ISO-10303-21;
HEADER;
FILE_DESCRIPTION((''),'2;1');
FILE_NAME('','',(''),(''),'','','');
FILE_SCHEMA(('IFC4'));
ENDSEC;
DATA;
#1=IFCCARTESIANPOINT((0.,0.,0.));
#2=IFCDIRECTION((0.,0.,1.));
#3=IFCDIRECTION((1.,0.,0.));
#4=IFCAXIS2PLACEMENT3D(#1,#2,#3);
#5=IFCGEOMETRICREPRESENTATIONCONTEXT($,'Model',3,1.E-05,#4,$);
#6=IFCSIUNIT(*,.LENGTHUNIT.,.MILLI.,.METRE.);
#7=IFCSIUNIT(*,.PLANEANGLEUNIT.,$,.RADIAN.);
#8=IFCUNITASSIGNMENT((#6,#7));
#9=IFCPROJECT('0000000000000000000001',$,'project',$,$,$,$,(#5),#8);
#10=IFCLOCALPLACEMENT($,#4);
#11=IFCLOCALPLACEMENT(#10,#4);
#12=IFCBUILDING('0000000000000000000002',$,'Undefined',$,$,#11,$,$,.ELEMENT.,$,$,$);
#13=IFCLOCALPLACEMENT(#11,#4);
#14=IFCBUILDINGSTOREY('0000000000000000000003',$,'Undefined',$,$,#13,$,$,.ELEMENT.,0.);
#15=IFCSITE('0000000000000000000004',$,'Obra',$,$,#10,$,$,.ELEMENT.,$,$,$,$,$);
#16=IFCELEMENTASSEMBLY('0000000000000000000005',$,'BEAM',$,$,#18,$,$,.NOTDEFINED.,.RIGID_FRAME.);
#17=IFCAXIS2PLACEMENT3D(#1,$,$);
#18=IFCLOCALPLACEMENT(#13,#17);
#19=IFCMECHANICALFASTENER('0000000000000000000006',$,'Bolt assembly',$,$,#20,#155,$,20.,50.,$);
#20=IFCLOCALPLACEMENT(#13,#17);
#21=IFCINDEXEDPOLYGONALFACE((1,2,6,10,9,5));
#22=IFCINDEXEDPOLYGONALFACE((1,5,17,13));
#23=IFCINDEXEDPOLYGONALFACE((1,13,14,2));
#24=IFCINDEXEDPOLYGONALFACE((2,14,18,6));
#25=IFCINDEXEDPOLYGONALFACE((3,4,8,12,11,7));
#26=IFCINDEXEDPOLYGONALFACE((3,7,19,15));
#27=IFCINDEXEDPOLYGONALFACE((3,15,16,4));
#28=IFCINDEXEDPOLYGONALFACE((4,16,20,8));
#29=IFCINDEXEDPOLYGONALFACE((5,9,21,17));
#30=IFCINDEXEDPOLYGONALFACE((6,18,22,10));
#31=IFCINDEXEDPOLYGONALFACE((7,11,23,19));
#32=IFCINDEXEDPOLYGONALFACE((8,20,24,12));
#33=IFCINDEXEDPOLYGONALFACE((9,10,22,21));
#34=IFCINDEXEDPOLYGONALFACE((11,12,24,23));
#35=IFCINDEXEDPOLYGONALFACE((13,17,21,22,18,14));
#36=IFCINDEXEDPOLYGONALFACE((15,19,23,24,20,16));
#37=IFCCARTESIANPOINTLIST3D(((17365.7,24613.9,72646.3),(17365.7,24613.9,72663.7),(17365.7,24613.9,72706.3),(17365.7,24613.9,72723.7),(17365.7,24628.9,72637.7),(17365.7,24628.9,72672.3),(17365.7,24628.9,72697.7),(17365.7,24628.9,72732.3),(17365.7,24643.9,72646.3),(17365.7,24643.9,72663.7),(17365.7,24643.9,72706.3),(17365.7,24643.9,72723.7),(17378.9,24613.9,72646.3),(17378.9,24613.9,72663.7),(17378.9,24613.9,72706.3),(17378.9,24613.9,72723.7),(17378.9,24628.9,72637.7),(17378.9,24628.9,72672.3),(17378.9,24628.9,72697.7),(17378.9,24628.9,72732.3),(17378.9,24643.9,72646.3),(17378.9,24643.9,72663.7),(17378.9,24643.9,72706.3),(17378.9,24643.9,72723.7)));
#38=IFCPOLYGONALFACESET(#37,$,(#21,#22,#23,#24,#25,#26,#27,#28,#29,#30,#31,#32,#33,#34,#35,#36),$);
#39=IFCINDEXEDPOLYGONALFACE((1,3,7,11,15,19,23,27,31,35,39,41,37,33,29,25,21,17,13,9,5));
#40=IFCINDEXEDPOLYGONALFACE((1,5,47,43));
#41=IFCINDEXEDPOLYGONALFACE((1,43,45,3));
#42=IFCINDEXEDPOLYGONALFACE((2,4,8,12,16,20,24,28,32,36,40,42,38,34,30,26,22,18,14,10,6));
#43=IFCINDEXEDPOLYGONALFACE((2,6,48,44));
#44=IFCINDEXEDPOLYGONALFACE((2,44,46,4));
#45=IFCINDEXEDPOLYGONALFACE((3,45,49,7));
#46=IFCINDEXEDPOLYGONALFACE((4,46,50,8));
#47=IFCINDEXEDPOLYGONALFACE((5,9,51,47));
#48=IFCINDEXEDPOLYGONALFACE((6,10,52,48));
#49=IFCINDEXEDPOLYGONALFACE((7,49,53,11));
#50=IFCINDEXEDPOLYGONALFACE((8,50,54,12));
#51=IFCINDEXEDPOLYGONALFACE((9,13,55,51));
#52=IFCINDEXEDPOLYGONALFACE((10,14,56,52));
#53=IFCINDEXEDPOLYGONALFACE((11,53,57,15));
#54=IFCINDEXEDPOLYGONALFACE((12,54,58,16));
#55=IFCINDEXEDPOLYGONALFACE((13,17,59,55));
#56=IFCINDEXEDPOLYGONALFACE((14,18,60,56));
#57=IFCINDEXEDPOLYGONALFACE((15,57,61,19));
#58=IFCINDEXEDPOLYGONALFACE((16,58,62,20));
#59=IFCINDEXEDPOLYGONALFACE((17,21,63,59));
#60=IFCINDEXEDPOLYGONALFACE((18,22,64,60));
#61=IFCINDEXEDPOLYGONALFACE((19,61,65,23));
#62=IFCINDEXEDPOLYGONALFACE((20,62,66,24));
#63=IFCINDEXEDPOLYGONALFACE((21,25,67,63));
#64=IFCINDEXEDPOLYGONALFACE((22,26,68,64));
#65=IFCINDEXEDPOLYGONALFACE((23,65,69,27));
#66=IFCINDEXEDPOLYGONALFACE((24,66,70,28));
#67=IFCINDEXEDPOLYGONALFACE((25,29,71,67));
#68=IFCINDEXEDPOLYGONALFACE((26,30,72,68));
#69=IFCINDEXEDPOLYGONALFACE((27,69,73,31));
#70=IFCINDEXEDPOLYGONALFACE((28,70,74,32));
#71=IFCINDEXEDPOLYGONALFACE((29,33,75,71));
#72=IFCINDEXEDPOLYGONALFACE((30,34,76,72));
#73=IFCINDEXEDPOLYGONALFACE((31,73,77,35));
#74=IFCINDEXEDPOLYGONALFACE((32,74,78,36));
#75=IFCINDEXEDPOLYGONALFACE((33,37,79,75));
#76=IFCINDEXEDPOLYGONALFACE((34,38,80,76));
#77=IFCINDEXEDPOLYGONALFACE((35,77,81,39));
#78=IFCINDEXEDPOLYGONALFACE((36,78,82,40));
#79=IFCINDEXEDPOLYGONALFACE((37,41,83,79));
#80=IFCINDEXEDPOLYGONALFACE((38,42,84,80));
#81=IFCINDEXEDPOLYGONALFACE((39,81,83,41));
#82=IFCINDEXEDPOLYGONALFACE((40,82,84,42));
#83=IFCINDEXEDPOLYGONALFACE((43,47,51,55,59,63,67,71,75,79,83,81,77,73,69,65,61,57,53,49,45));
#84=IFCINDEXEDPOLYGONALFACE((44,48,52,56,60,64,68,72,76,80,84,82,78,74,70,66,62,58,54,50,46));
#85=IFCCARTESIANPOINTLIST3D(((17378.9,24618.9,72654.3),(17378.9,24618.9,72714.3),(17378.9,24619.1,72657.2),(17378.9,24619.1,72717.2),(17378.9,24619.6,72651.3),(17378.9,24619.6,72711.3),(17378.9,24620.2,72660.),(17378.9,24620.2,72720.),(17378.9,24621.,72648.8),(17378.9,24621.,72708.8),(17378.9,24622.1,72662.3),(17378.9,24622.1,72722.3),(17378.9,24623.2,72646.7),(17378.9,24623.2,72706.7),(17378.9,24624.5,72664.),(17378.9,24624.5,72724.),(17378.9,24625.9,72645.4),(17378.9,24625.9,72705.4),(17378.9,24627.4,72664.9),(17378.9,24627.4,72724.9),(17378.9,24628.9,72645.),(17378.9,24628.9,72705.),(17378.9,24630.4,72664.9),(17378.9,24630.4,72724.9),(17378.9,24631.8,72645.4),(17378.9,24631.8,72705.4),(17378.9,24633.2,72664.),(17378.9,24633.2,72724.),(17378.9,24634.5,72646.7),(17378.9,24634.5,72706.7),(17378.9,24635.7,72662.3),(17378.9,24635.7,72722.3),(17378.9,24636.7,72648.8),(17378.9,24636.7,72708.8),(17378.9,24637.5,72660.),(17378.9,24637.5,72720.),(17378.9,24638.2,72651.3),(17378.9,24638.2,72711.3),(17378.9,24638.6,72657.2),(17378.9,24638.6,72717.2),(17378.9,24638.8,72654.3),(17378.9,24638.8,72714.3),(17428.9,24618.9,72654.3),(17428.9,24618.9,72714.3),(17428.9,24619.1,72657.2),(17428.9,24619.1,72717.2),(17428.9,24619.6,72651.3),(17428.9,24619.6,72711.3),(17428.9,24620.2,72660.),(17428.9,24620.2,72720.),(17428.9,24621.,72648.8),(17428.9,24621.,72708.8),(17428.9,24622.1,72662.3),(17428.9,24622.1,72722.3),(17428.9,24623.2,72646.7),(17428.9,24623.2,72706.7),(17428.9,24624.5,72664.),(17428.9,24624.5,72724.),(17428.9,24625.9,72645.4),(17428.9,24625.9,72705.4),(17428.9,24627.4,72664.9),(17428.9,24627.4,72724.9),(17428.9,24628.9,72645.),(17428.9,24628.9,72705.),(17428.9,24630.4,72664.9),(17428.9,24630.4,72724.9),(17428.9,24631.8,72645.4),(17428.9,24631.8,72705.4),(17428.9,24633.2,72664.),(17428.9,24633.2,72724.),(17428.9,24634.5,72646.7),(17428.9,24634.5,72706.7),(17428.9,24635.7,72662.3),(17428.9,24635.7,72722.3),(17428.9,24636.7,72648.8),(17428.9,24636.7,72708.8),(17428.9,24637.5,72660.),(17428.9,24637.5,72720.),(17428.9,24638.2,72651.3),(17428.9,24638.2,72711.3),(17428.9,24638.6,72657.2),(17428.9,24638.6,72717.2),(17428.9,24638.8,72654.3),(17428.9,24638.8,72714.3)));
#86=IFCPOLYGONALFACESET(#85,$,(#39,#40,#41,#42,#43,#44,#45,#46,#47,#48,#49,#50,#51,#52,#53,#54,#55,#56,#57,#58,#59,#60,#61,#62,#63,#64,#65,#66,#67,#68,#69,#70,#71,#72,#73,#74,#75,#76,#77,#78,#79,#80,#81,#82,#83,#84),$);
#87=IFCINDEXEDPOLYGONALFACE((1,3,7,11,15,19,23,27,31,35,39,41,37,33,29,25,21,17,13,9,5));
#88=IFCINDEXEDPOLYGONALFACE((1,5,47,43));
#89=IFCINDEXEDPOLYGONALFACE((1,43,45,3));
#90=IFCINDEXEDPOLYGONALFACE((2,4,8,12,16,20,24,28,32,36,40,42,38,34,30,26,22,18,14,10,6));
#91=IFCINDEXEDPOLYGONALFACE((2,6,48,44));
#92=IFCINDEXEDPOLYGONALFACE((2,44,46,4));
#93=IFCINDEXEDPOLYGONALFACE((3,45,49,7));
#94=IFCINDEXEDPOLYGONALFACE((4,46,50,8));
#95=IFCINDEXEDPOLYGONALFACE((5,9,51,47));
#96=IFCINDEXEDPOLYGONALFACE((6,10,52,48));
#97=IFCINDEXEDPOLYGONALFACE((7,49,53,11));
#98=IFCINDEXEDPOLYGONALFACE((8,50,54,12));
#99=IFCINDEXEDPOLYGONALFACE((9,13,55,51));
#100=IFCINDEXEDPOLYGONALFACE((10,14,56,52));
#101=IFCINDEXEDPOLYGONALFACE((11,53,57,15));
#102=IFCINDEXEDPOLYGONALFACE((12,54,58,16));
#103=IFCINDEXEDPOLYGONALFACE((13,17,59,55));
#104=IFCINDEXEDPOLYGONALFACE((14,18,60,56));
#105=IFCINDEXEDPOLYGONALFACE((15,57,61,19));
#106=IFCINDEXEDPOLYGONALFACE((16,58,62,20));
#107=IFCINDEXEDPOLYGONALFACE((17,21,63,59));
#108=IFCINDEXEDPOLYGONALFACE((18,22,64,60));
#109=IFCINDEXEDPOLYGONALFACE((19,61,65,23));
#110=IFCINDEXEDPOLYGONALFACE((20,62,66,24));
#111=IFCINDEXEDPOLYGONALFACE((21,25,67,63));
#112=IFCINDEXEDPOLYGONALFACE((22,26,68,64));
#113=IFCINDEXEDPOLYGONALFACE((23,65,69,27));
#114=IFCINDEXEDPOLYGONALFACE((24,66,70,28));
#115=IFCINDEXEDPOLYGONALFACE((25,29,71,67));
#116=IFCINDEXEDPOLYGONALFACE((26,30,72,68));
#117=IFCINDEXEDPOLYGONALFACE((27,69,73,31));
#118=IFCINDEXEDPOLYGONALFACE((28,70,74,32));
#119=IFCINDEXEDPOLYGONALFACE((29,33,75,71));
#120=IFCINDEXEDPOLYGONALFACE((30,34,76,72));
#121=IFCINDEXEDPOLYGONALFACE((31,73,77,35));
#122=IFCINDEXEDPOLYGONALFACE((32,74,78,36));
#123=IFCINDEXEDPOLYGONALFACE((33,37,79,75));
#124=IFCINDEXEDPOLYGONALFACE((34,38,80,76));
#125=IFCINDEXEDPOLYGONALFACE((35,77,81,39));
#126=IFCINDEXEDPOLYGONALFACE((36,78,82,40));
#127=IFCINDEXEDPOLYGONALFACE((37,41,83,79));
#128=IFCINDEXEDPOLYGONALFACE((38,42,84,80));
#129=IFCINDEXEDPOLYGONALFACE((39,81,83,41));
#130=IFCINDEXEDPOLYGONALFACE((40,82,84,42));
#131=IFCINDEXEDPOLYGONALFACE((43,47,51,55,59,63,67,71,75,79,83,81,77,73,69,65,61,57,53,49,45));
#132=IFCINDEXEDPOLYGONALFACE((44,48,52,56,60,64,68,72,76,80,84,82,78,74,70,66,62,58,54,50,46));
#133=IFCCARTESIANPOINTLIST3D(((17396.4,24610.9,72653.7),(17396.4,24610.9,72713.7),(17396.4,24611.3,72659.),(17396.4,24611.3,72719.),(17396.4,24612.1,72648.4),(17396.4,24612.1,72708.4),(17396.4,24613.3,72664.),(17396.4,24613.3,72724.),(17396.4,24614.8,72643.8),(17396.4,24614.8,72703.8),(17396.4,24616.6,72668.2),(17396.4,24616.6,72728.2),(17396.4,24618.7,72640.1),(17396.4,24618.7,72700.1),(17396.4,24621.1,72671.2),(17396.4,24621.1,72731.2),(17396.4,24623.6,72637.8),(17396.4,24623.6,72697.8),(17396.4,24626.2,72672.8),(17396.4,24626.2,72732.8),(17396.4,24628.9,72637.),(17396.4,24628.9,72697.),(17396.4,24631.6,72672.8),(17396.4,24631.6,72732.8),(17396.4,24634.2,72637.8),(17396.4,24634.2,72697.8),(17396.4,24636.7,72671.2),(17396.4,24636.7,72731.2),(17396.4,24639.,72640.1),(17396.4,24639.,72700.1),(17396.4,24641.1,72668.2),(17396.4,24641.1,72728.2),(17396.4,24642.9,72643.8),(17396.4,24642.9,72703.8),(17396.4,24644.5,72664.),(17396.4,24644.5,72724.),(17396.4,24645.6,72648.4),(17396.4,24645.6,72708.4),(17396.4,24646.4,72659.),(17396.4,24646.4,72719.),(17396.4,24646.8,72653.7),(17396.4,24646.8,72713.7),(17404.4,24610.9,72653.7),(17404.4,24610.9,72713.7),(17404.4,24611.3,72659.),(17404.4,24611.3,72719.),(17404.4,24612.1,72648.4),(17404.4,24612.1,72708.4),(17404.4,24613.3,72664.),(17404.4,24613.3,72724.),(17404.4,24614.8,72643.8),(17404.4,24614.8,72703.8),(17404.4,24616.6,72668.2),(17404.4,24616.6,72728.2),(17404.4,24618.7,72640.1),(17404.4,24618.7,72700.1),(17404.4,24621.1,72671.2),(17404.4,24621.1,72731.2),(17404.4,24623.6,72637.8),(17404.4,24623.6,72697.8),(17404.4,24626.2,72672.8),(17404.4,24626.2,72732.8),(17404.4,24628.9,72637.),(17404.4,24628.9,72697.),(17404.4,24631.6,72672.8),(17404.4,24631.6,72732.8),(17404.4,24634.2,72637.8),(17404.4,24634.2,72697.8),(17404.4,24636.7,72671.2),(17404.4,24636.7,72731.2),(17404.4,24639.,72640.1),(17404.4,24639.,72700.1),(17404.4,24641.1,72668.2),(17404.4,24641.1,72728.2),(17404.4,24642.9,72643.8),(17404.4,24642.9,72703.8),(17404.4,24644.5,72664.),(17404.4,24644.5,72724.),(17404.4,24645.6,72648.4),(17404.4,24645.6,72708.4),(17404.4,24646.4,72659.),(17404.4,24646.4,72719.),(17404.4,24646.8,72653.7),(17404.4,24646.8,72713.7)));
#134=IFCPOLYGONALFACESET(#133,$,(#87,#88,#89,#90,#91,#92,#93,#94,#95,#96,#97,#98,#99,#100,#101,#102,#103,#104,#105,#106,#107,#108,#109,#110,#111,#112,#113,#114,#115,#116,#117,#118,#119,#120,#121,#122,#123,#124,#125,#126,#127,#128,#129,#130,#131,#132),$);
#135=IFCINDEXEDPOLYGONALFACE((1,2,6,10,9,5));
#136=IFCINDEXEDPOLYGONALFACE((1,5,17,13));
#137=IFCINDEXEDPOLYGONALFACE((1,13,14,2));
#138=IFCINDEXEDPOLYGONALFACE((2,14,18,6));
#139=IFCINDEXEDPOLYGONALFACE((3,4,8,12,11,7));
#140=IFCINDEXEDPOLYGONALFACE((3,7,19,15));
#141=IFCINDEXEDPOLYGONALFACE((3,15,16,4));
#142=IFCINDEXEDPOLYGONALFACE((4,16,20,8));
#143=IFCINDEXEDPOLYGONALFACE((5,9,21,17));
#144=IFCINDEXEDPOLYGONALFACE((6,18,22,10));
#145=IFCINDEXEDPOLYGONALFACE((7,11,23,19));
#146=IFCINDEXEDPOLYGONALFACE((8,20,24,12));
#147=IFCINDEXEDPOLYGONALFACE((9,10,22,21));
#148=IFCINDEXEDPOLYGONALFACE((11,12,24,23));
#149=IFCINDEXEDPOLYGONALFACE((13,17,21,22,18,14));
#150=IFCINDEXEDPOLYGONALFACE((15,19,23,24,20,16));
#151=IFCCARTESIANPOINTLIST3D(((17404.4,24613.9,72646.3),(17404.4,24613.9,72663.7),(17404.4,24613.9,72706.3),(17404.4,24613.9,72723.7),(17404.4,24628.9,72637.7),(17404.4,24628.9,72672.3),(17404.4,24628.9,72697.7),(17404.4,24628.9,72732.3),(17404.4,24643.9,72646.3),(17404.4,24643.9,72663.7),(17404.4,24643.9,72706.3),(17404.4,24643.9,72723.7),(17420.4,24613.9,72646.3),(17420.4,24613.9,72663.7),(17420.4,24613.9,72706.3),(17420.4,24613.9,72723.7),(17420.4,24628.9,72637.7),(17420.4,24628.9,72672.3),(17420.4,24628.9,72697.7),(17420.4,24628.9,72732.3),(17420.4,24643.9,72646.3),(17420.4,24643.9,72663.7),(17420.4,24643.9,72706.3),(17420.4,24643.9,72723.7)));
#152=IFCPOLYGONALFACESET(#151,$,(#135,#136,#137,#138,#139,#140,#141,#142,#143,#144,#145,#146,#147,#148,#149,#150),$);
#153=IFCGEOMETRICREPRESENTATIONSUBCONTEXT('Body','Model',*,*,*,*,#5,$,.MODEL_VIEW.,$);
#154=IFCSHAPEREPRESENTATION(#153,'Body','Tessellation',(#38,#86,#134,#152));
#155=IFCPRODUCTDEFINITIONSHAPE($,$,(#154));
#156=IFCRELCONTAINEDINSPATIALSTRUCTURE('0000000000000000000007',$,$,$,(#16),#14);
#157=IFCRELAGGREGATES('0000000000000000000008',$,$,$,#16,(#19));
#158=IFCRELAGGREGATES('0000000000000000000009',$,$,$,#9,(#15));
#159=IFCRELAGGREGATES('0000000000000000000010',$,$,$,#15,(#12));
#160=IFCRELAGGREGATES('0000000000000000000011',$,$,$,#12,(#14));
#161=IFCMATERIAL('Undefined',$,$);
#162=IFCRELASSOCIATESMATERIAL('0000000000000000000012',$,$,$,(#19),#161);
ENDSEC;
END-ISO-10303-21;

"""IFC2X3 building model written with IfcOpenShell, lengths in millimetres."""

from ifc_helpers import new_model, si_unit, frame, origin_with_axes, origin_2d_with_axis, place, context, subcontext, project, spatial, polyline, circle, outline, extrude, source, transform, mapped, material, element, aggregate, save


model = new_model("IFC2X3")

# Units and contexts
model_context = context("Model", 3, precision=1e-05, world=origin_with_axes())
body_context = subcontext(model_context, "Body", "Model", "MODEL_VIEW")
ifc_project = project(units=[si_unit("LENGTHUNIT", "METRE", prefix="MILLI"), si_unit("PLANEANGLEUNIT", "RADIAN")], contexts=[model_context])

# Site, building, storey
site_placement = place(None, origin_with_axes())
site = spatial("IfcSite", under=ifc_project, at=site_placement, Name="Obra", CompositionType="ELEMENT")
building_placement = place(site_placement, origin_with_axes())
building = spatial("IfcBuilding", under=site, at=building_placement, Name="Undefined", CompositionType="ELEMENT")
storey_placement = place(building_placement, origin_with_axes())
storey = spatial("IfcBuildingStorey", under=building, at=storey_placement, Name="Undefined", CompositionType="ELEMENT", Elevation=0.0)

# Shared definitions
ifc_material = material(Name="Undefined")

# Element assembly
assembly_1_placement = place(storey_placement, origin_with_axes())
assembly_1 = element("IfcElementAssembly", 1, at=assembly_1_placement, inside=storey, Name="BEAM", AssemblyPlace="NOTDEFINED", PredefinedType="RIGID_FRAME")
shared_shape_1 = source(origin_with_axes(), body_context, "Body", "SweptSolid", [
    extrude(outline(polyline([(17.3, 0.0), (8.7, 15.0), (-8.7, 15.0), (-17.3, 0.0), (-8.7, -15.0), (8.7, -15.0), (17.3, 0.0)])), frame((0.0, -27.0, 0.0), z_axis=(0.0, 1.0, 0.0), x_axis=(1.0, 0.0, 0.0)), (0.0, 0.0, 1.0), 13.2),
    extrude(circle(Radius=10.0, at=origin_2d_with_axis()), frame((0.0, -13.8, 0.0), z_axis=(0.0, 1.0, 0.0), x_axis=(1.0, 0.0, 0.0)), (0.0, 0.0, 1.0), 50.0),
    extrude(circle(Radius=18.0, at=origin_2d_with_axis()), frame((0.0, 3.7, 0.0), z_axis=(0.0, 1.0, 0.0), x_axis=(1.0, 0.0, 0.0)), (0.0, 0.0, 1.0), 8.0),
    extrude(outline(polyline([(17.3, 0.0), (8.7, 15.0), (-8.7, 15.0), (-17.3, 0.0), (-8.7, -15.0), (8.7, -15.0), (17.3, 0.0)])), frame((0.0, 11.7, 0.0), z_axis=(0.0, 1.0, 0.0), x_axis=(1.0, 0.0, 0.0)), (0.0, 0.0, 1.0), 16.0),
])

# Mechanical fastener
mechanical_fastener_1_placement = place(assembly_1_placement, frame((17392.7, 24668.9, 72850.0), z_axis=(0.000002, -1.0, 0.0), x_axis=(0.0, 0.0, -1.0)))
mechanical_fastener_1 = element("IfcMechanicalFastener", 2, at=mechanical_fastener_1_placement, material=ifc_material, Name="Bolt assembly", NominalDiameter=20.0, NominalLength=50.0, context=body_context, shape_type="MappedRepresentation", body=[
    mapped(shared_shape_1, transform((135.0, 0.0, 40.0))),
    mapped(shared_shape_1, transform((195.0, 0.0, 40.0))),
])
aggregate(assembly_1, [mechanical_fastener_1])

save(model, "model.ifc")
